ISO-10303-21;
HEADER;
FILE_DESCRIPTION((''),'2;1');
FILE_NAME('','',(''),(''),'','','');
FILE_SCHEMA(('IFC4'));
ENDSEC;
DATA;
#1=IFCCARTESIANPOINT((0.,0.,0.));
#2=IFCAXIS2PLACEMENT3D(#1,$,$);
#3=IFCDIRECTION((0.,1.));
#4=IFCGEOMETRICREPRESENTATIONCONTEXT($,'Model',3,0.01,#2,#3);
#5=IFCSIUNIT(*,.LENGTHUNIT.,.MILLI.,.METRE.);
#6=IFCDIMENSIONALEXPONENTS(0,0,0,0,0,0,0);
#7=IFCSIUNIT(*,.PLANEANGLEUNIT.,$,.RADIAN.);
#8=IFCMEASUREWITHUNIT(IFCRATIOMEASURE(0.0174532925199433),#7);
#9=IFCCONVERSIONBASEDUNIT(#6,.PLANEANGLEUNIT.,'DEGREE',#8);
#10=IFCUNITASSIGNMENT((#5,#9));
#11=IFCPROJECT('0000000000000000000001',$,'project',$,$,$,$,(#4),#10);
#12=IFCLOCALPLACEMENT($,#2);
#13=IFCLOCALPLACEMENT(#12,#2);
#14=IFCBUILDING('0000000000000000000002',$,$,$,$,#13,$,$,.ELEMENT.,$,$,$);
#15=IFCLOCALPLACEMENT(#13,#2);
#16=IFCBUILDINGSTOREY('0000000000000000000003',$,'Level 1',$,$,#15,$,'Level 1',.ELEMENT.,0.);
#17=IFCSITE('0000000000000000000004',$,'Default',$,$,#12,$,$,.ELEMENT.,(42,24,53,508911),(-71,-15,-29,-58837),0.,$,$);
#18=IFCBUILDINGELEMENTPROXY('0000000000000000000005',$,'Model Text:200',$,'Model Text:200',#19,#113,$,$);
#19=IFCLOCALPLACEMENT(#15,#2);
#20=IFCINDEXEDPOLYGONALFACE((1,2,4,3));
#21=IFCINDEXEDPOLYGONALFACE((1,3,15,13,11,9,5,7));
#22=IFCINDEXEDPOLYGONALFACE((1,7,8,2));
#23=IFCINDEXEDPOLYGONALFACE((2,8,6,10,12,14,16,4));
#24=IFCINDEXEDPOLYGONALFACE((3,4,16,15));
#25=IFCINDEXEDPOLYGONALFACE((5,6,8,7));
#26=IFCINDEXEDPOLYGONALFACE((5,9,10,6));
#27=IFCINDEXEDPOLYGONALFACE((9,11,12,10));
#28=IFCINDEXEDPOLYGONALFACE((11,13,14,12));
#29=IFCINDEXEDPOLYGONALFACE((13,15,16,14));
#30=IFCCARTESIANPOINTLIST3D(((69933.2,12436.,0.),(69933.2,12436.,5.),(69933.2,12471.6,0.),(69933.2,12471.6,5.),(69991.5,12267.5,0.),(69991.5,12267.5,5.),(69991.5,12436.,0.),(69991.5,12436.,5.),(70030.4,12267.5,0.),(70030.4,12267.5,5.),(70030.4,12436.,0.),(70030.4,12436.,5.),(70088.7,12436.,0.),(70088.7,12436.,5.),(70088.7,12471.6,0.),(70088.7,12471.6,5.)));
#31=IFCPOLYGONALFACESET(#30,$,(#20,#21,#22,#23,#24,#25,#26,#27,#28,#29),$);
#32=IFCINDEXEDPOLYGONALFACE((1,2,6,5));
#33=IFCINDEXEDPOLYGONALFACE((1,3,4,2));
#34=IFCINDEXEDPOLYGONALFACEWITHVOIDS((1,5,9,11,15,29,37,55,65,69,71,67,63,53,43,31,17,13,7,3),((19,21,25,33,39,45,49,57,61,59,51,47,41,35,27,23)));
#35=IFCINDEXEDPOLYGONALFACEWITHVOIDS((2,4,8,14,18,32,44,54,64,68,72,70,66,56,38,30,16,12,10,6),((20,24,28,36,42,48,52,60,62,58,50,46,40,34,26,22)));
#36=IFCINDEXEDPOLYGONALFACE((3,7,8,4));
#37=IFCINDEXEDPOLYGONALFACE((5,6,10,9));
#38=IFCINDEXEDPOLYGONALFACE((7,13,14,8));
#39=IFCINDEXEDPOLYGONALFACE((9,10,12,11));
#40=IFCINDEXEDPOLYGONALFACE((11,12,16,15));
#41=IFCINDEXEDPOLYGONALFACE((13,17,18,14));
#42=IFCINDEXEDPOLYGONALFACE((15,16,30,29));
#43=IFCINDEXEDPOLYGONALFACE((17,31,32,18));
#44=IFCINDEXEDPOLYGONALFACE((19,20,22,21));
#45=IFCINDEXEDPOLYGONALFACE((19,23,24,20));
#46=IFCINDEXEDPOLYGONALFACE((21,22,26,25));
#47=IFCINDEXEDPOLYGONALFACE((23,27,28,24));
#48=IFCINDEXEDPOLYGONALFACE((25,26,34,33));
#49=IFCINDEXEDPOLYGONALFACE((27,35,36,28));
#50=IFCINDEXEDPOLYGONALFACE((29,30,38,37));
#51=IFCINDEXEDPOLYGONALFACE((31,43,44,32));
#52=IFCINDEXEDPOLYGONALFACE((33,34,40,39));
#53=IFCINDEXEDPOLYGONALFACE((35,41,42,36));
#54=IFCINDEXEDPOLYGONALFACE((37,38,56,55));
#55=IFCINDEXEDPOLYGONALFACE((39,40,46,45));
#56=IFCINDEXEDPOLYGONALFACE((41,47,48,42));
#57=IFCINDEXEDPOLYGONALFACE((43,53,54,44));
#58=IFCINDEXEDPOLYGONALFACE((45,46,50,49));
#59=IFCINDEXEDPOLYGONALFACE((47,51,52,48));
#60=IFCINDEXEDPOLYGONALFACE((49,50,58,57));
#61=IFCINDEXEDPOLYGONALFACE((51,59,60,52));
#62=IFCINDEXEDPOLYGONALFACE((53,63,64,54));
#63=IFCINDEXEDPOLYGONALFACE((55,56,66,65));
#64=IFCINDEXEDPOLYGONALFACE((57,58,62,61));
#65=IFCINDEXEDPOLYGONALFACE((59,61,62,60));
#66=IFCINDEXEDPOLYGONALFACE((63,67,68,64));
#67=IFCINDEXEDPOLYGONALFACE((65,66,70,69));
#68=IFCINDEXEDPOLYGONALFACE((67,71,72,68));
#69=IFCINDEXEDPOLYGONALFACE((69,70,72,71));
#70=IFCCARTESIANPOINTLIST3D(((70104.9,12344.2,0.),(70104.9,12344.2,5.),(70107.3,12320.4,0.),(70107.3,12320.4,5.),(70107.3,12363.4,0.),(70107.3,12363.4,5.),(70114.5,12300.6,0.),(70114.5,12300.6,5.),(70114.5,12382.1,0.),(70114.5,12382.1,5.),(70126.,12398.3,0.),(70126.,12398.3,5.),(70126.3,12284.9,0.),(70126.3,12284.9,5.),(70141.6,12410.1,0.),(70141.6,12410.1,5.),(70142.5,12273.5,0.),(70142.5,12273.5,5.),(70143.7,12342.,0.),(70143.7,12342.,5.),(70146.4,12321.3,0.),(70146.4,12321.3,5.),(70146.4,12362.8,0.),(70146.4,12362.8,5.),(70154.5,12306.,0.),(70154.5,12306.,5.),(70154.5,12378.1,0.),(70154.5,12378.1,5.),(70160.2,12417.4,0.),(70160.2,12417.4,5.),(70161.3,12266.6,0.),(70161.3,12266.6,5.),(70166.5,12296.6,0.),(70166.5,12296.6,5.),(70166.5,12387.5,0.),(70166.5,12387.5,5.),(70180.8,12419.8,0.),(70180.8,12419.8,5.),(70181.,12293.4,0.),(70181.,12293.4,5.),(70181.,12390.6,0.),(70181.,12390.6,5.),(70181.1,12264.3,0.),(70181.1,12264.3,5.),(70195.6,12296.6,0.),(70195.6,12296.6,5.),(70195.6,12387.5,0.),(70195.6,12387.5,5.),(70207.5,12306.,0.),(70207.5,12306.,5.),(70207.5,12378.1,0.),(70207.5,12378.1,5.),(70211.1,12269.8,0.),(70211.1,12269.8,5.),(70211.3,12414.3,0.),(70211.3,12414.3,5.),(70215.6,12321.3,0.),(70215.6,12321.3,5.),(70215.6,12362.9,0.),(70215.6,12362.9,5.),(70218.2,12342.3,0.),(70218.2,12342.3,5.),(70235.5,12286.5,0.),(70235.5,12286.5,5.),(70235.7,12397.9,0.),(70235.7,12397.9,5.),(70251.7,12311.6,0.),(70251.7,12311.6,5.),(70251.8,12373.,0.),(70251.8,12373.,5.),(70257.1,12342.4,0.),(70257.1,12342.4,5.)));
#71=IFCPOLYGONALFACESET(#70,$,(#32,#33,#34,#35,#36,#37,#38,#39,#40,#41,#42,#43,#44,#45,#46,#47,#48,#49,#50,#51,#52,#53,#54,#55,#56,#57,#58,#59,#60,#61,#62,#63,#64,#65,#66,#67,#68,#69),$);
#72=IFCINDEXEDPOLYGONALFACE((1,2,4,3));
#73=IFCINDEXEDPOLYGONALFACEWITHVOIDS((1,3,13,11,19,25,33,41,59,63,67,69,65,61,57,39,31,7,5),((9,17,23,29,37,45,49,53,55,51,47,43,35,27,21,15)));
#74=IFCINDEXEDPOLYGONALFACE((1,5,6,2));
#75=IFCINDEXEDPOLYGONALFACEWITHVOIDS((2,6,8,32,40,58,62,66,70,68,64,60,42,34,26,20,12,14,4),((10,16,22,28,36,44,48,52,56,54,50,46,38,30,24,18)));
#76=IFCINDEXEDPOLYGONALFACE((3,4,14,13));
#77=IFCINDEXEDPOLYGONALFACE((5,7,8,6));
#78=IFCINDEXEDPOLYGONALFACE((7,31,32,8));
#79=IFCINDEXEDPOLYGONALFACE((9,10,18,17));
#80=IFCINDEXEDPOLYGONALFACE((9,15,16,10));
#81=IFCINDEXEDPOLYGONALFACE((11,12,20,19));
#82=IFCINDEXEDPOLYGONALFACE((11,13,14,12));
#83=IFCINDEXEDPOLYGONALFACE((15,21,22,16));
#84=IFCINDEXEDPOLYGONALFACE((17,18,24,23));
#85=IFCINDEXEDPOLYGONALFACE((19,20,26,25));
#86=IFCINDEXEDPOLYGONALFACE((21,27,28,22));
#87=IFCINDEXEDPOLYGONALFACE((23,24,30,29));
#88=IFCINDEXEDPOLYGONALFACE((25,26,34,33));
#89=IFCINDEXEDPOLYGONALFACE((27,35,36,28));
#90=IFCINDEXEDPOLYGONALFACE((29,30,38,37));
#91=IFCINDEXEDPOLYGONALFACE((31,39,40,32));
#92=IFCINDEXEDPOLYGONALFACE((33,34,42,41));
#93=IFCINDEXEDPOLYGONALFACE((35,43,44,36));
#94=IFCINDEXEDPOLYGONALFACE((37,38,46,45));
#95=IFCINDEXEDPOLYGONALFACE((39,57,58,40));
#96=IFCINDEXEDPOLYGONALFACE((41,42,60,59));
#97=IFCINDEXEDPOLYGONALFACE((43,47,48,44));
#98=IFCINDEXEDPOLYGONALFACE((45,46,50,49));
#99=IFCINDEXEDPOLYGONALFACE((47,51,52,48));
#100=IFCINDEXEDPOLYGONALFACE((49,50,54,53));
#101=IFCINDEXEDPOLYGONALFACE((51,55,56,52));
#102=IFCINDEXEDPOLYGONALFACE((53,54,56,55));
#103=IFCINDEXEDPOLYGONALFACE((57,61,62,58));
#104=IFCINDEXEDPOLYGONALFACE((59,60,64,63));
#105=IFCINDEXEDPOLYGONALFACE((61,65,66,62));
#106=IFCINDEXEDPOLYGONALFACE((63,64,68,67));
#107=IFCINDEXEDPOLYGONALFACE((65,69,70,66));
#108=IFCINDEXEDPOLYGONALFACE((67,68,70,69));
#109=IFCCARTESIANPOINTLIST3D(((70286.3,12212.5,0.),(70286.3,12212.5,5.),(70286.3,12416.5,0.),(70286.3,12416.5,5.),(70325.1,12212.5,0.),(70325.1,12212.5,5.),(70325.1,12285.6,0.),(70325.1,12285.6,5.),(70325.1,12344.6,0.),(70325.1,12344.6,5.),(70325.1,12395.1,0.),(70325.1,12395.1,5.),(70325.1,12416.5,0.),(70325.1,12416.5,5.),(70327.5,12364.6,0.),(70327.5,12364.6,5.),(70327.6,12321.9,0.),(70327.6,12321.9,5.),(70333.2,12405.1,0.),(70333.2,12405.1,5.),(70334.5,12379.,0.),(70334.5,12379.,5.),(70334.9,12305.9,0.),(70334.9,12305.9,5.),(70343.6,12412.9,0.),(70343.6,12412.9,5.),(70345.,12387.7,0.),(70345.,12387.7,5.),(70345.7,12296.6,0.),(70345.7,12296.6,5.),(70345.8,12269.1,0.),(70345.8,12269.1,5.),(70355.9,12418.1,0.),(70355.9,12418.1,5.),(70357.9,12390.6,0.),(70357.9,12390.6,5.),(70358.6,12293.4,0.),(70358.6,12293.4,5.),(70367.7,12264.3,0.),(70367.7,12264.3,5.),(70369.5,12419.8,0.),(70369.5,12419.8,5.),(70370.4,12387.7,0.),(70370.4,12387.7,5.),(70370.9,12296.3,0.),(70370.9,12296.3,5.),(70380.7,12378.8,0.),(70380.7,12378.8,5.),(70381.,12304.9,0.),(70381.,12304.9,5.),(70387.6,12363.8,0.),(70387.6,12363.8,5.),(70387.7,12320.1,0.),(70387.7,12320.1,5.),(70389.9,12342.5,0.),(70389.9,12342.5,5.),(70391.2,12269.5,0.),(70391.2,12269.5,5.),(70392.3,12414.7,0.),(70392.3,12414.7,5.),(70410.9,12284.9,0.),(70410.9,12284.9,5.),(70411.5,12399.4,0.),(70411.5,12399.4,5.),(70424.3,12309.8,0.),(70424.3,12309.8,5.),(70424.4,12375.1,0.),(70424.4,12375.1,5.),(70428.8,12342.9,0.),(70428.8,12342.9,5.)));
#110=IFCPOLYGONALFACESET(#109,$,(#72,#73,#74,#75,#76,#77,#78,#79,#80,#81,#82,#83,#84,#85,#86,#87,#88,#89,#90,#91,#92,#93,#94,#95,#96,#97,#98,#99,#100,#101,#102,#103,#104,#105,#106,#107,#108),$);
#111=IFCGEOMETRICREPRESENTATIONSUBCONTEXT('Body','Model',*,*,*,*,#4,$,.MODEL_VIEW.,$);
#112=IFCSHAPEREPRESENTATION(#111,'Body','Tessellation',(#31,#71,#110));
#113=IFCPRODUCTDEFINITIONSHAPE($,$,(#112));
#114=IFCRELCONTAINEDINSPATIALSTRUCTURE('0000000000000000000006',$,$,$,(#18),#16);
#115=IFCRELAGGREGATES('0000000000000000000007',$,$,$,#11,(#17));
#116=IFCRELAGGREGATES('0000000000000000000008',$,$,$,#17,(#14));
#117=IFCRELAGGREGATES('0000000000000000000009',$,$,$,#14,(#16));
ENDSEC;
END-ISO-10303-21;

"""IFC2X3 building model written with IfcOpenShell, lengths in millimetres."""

from ifc_helpers import new_model, entity, si_unit, converted_unit, direction, frame, origin, place, context, subcontext, project, spatial, polyline, outline, extrude, element, save


model = new_model("IFC2X3")

# Units and contexts
model_context = context("Model", 3, precision=0.01, world=origin(), true_north=direction((0.0, 1.0)))
body_context = subcontext(model_context, "Body", "Model", "MODEL_VIEW")
ifc_project = project(units=[si_unit("LENGTHUNIT", "METRE", prefix="MILLI"), converted_unit("PLANEANGLEUNIT", "DEGREE", entity("IfcRatioMeasure", 0.0174532925199433), si_unit("PLANEANGLEUNIT", "RADIAN"), dimensions=[0, 0, 0, 0, 0, 0, 0])], contexts=[model_context])

# Site, building, storey
site_placement = place(None, origin())
site = spatial("IfcSite", under=ifc_project, at=site_placement, Name="Default", CompositionType="ELEMENT", RefLatitude=(42, 24, 53, 508911), RefLongitude=(-71, -15, -29, -58837), RefElevation=0.0)
building_placement = place(site_placement, origin())
building = spatial("IfcBuilding", under=site, at=building_placement, CompositionType="ELEMENT")
storey_placement = place(building_placement, origin())
storey = spatial("IfcBuildingStorey", under=building, at=storey_placement, Name="Level 1", LongName="Level 1", CompositionType="ELEMENT", Elevation=0.0)

# Building element proxy
proxy_1_placement = place(storey_placement, origin())
element("IfcBuildingElementProxy", 1, at=proxy_1_placement, inside=storey, Name="Model Text:200", ObjectType="Model Text:200", context=body_context, shape_type="SweptSolid", body=[
    extrude(outline(polyline([(-19.4, -135.2), (19.4, -135.2), (19.4, 33.2), (77.7, 33.2), (77.7, 68.8), (-77.7, 68.8), (-77.7, 33.2), (-19.4, 33.2), (-19.4, -135.2)])), frame((70010.9, 12402.8, 0.0)), (0.0, 0.0, 1.0), 5.0),
    extrude(outline(polyline([(-8.8, -65.7), (15.1, -65.7), (35.5, -60.5), (52.3, -50.4), (65.3, -35.4), (74.1, -17.3), (78.4, 2.1), (75.9, 32.5), (61.8, 58.5), (38.4, 77.1), (8.3, 85.6), (-22.7, 83.3), (-49.0, 69.9), (-67.8, 47.3), (-76.3, 17.5), (-76.0, -3.3), (-70.7, -22.5), (-60.5, -39.2), (-45.5, -52.3), (-27.7, -61.4), (-8.8, -65.7)]), holes=[polyline([(-2.7, -27.2), (-23.1, -22.5), (-37.5, -12.9), (-45.7, 0.0), (-47.3, 14.8), (-42.7, 28.9), (-32.2, 39.9), (-16.3, 46.3), (4.5, 46.9), (25.1, 42.1), (39.6, 32.6), (47.7, 19.7), (49.4, 5.0), (44.8, -9.2), (34.2, -20.2), (18.2, -26.7), (-2.7, -27.2)])]), frame((70171.1, 12342.1, 0.0), z_axis=(0.0, 0.0, 1.0), x_axis=(0.100608, -0.994926, 0.0)), (0.0, 0.0, 1.0), 5.0),
    extrude(outline(polyline([(-73.1, -75.4), (130.9, -75.4), (130.9, -36.6), (57.8, -36.6), (74.3, -15.9), (79.1, 6.0), (73.9, 29.5), (58.4, 49.2), (33.6, 62.6), (0.5, 67.1), (-31.8, 62.8), (-56.1, 49.8), (-71.3, 30.7), (-76.4, 7.8), (-74.7, -5.8), (-69.6, -18.1), (-61.7, -28.5), (-51.7, -36.6), (-73.1, -36.6), (-73.1, -75.4)]), holes=[polyline([(-1.2, -36.6), (-21.2, -34.2), (-35.6, -27.2), (-44.3, -16.7), (-47.2, -3.8), (-44.3, 8.7), (-35.4, 19.0), (-20.4, 25.9), (0.8, 28.2), (23.3, 26.0), (38.5, 19.3), (47.1, 9.2), (49.9, -3.1), (46.8, -16.0), (37.4, -26.8), (21.5, -34.1), (-1.2, -36.6)])]), frame((70361.7, 12343.4, 0.0), z_axis=(0.0, 0.0, 1.0), x_axis=(0.0, -1.0, 0.0)), (0.0, 0.0, 1.0), 5.0),
])

save(model, "model.ifc")
